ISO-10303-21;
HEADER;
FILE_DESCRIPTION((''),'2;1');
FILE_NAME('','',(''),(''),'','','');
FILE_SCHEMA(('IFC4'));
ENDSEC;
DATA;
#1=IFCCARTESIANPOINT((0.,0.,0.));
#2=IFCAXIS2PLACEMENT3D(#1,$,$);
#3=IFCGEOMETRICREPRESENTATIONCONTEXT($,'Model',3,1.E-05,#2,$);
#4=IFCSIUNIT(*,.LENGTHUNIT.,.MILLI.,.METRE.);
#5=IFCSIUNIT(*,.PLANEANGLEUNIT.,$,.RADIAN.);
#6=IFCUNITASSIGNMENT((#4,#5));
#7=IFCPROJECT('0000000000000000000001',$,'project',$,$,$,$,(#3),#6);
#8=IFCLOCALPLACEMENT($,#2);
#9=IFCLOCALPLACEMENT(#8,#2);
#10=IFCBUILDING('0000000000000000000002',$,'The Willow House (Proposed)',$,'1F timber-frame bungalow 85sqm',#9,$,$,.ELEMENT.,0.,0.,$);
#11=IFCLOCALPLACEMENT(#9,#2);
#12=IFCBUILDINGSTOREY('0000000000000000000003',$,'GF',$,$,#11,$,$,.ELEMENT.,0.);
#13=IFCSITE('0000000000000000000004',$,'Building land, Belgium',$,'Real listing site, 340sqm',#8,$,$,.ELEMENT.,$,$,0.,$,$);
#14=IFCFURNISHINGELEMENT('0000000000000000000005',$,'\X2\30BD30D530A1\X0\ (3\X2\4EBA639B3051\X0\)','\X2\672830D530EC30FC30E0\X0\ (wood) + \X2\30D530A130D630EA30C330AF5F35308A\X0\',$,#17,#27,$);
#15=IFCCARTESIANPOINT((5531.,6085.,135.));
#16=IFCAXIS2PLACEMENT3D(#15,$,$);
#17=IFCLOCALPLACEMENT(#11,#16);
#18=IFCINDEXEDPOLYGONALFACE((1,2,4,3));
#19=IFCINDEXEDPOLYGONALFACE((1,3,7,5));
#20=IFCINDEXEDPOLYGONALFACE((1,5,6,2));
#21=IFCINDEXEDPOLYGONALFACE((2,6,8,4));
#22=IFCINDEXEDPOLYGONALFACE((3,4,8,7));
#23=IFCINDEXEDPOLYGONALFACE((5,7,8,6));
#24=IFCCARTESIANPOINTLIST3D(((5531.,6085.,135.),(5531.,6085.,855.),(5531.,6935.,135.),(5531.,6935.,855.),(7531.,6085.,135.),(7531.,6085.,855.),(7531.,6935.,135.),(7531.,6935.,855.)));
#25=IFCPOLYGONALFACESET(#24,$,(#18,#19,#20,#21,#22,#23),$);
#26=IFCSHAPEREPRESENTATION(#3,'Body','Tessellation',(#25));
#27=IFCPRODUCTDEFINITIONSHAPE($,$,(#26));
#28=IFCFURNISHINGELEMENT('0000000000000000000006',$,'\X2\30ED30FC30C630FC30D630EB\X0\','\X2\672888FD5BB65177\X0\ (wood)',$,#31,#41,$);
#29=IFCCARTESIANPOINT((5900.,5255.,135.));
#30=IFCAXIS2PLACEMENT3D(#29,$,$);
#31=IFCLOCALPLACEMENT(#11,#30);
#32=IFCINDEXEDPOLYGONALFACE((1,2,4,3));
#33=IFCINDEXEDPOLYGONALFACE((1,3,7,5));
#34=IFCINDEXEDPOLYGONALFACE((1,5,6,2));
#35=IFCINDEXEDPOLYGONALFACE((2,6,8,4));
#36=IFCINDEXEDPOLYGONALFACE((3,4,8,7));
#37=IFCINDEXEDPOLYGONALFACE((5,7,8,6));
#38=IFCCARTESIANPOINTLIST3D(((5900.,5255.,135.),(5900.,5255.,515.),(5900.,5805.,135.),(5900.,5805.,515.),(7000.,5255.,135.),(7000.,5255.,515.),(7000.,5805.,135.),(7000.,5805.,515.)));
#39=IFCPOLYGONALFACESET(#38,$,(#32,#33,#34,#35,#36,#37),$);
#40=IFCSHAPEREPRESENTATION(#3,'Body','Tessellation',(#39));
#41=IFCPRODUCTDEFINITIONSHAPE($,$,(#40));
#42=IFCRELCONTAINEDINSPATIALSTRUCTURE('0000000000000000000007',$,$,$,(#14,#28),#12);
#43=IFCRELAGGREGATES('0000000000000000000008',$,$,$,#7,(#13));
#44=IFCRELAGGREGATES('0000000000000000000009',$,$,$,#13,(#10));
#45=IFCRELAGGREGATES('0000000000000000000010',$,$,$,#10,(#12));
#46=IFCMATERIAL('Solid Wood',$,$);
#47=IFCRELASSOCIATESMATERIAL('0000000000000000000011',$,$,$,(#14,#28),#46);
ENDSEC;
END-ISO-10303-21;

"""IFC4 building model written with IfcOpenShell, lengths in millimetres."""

from ifc_helpers import new_model, si_unit, frame, frame_2d, origin, place, context, project, spatial, rectangle, extrude, material, element, save


model = new_model("IFC4")

# Units and contexts
model_context = context("Model", 3, precision=1e-05, world=origin())
ifc_project = project(units=[si_unit("LENGTHUNIT", "METRE", prefix="MILLI"), si_unit("PLANEANGLEUNIT", "RADIAN")], contexts=[model_context])

# Site, building, storey
site_placement = place(None, origin())
site = spatial("IfcSite", under=ifc_project, at=site_placement, Name="Building land, Belgium", ObjectType="Real listing site, 340sqm", CompositionType="ELEMENT", RefElevation=0.0)
building_placement = place(site_placement, origin())
building = spatial("IfcBuilding", under=site, at=building_placement, Name="The Willow House (Proposed)", ObjectType="1F timber-frame bungalow 85sqm", CompositionType="ELEMENT", ElevationOfRefHeight=0.0, ElevationOfTerrain=0.0)
storey_placement = place(building_placement, origin())
storey = spatial("IfcBuildingStorey", under=building, at=storey_placement, Name="GF", CompositionType="ELEMENT", Elevation=0.0)

# Shared definitions
ifc_material_1 = material(Name="Solid Wood")

# Furnishing elements
furnishing_1_placement = place(storey_placement, frame((5531.0, 6085.0, 135.0)))
element("IfcFurnishingElement", 1, at=furnishing_1_placement, inside=storey, material=ifc_material_1, Name="ソファ (3人掛け)", Description="木フレーム (wood) + ファブリック張り", context=model_context, shape_type="SweptSolid", body=[
    extrude(rectangle(XDim=2000.0, YDim=850.0, at=frame_2d((1000.0, 425.0))), frame((5531.0, 6085.0, 135.0)), (0.0, 0.0, 1.0), 720.0),
])
furnishing_2_placement = place(storey_placement, frame((5900.0, 5255.0, 135.0)))
element("IfcFurnishingElement", 2, at=furnishing_2_placement, inside=storey, material=ifc_material_1, Name="ローテーブル", Description="木製家具 (wood)", context=model_context, shape_type="SweptSolid", body=[
    extrude(rectangle(XDim=1100.0, YDim=550.0, at=frame_2d((550.0, 275.0))), frame((5900.0, 5255.0, 135.0)), (0.0, 0.0, 1.0), 380.0),
])

save(model, "model.ifc")
